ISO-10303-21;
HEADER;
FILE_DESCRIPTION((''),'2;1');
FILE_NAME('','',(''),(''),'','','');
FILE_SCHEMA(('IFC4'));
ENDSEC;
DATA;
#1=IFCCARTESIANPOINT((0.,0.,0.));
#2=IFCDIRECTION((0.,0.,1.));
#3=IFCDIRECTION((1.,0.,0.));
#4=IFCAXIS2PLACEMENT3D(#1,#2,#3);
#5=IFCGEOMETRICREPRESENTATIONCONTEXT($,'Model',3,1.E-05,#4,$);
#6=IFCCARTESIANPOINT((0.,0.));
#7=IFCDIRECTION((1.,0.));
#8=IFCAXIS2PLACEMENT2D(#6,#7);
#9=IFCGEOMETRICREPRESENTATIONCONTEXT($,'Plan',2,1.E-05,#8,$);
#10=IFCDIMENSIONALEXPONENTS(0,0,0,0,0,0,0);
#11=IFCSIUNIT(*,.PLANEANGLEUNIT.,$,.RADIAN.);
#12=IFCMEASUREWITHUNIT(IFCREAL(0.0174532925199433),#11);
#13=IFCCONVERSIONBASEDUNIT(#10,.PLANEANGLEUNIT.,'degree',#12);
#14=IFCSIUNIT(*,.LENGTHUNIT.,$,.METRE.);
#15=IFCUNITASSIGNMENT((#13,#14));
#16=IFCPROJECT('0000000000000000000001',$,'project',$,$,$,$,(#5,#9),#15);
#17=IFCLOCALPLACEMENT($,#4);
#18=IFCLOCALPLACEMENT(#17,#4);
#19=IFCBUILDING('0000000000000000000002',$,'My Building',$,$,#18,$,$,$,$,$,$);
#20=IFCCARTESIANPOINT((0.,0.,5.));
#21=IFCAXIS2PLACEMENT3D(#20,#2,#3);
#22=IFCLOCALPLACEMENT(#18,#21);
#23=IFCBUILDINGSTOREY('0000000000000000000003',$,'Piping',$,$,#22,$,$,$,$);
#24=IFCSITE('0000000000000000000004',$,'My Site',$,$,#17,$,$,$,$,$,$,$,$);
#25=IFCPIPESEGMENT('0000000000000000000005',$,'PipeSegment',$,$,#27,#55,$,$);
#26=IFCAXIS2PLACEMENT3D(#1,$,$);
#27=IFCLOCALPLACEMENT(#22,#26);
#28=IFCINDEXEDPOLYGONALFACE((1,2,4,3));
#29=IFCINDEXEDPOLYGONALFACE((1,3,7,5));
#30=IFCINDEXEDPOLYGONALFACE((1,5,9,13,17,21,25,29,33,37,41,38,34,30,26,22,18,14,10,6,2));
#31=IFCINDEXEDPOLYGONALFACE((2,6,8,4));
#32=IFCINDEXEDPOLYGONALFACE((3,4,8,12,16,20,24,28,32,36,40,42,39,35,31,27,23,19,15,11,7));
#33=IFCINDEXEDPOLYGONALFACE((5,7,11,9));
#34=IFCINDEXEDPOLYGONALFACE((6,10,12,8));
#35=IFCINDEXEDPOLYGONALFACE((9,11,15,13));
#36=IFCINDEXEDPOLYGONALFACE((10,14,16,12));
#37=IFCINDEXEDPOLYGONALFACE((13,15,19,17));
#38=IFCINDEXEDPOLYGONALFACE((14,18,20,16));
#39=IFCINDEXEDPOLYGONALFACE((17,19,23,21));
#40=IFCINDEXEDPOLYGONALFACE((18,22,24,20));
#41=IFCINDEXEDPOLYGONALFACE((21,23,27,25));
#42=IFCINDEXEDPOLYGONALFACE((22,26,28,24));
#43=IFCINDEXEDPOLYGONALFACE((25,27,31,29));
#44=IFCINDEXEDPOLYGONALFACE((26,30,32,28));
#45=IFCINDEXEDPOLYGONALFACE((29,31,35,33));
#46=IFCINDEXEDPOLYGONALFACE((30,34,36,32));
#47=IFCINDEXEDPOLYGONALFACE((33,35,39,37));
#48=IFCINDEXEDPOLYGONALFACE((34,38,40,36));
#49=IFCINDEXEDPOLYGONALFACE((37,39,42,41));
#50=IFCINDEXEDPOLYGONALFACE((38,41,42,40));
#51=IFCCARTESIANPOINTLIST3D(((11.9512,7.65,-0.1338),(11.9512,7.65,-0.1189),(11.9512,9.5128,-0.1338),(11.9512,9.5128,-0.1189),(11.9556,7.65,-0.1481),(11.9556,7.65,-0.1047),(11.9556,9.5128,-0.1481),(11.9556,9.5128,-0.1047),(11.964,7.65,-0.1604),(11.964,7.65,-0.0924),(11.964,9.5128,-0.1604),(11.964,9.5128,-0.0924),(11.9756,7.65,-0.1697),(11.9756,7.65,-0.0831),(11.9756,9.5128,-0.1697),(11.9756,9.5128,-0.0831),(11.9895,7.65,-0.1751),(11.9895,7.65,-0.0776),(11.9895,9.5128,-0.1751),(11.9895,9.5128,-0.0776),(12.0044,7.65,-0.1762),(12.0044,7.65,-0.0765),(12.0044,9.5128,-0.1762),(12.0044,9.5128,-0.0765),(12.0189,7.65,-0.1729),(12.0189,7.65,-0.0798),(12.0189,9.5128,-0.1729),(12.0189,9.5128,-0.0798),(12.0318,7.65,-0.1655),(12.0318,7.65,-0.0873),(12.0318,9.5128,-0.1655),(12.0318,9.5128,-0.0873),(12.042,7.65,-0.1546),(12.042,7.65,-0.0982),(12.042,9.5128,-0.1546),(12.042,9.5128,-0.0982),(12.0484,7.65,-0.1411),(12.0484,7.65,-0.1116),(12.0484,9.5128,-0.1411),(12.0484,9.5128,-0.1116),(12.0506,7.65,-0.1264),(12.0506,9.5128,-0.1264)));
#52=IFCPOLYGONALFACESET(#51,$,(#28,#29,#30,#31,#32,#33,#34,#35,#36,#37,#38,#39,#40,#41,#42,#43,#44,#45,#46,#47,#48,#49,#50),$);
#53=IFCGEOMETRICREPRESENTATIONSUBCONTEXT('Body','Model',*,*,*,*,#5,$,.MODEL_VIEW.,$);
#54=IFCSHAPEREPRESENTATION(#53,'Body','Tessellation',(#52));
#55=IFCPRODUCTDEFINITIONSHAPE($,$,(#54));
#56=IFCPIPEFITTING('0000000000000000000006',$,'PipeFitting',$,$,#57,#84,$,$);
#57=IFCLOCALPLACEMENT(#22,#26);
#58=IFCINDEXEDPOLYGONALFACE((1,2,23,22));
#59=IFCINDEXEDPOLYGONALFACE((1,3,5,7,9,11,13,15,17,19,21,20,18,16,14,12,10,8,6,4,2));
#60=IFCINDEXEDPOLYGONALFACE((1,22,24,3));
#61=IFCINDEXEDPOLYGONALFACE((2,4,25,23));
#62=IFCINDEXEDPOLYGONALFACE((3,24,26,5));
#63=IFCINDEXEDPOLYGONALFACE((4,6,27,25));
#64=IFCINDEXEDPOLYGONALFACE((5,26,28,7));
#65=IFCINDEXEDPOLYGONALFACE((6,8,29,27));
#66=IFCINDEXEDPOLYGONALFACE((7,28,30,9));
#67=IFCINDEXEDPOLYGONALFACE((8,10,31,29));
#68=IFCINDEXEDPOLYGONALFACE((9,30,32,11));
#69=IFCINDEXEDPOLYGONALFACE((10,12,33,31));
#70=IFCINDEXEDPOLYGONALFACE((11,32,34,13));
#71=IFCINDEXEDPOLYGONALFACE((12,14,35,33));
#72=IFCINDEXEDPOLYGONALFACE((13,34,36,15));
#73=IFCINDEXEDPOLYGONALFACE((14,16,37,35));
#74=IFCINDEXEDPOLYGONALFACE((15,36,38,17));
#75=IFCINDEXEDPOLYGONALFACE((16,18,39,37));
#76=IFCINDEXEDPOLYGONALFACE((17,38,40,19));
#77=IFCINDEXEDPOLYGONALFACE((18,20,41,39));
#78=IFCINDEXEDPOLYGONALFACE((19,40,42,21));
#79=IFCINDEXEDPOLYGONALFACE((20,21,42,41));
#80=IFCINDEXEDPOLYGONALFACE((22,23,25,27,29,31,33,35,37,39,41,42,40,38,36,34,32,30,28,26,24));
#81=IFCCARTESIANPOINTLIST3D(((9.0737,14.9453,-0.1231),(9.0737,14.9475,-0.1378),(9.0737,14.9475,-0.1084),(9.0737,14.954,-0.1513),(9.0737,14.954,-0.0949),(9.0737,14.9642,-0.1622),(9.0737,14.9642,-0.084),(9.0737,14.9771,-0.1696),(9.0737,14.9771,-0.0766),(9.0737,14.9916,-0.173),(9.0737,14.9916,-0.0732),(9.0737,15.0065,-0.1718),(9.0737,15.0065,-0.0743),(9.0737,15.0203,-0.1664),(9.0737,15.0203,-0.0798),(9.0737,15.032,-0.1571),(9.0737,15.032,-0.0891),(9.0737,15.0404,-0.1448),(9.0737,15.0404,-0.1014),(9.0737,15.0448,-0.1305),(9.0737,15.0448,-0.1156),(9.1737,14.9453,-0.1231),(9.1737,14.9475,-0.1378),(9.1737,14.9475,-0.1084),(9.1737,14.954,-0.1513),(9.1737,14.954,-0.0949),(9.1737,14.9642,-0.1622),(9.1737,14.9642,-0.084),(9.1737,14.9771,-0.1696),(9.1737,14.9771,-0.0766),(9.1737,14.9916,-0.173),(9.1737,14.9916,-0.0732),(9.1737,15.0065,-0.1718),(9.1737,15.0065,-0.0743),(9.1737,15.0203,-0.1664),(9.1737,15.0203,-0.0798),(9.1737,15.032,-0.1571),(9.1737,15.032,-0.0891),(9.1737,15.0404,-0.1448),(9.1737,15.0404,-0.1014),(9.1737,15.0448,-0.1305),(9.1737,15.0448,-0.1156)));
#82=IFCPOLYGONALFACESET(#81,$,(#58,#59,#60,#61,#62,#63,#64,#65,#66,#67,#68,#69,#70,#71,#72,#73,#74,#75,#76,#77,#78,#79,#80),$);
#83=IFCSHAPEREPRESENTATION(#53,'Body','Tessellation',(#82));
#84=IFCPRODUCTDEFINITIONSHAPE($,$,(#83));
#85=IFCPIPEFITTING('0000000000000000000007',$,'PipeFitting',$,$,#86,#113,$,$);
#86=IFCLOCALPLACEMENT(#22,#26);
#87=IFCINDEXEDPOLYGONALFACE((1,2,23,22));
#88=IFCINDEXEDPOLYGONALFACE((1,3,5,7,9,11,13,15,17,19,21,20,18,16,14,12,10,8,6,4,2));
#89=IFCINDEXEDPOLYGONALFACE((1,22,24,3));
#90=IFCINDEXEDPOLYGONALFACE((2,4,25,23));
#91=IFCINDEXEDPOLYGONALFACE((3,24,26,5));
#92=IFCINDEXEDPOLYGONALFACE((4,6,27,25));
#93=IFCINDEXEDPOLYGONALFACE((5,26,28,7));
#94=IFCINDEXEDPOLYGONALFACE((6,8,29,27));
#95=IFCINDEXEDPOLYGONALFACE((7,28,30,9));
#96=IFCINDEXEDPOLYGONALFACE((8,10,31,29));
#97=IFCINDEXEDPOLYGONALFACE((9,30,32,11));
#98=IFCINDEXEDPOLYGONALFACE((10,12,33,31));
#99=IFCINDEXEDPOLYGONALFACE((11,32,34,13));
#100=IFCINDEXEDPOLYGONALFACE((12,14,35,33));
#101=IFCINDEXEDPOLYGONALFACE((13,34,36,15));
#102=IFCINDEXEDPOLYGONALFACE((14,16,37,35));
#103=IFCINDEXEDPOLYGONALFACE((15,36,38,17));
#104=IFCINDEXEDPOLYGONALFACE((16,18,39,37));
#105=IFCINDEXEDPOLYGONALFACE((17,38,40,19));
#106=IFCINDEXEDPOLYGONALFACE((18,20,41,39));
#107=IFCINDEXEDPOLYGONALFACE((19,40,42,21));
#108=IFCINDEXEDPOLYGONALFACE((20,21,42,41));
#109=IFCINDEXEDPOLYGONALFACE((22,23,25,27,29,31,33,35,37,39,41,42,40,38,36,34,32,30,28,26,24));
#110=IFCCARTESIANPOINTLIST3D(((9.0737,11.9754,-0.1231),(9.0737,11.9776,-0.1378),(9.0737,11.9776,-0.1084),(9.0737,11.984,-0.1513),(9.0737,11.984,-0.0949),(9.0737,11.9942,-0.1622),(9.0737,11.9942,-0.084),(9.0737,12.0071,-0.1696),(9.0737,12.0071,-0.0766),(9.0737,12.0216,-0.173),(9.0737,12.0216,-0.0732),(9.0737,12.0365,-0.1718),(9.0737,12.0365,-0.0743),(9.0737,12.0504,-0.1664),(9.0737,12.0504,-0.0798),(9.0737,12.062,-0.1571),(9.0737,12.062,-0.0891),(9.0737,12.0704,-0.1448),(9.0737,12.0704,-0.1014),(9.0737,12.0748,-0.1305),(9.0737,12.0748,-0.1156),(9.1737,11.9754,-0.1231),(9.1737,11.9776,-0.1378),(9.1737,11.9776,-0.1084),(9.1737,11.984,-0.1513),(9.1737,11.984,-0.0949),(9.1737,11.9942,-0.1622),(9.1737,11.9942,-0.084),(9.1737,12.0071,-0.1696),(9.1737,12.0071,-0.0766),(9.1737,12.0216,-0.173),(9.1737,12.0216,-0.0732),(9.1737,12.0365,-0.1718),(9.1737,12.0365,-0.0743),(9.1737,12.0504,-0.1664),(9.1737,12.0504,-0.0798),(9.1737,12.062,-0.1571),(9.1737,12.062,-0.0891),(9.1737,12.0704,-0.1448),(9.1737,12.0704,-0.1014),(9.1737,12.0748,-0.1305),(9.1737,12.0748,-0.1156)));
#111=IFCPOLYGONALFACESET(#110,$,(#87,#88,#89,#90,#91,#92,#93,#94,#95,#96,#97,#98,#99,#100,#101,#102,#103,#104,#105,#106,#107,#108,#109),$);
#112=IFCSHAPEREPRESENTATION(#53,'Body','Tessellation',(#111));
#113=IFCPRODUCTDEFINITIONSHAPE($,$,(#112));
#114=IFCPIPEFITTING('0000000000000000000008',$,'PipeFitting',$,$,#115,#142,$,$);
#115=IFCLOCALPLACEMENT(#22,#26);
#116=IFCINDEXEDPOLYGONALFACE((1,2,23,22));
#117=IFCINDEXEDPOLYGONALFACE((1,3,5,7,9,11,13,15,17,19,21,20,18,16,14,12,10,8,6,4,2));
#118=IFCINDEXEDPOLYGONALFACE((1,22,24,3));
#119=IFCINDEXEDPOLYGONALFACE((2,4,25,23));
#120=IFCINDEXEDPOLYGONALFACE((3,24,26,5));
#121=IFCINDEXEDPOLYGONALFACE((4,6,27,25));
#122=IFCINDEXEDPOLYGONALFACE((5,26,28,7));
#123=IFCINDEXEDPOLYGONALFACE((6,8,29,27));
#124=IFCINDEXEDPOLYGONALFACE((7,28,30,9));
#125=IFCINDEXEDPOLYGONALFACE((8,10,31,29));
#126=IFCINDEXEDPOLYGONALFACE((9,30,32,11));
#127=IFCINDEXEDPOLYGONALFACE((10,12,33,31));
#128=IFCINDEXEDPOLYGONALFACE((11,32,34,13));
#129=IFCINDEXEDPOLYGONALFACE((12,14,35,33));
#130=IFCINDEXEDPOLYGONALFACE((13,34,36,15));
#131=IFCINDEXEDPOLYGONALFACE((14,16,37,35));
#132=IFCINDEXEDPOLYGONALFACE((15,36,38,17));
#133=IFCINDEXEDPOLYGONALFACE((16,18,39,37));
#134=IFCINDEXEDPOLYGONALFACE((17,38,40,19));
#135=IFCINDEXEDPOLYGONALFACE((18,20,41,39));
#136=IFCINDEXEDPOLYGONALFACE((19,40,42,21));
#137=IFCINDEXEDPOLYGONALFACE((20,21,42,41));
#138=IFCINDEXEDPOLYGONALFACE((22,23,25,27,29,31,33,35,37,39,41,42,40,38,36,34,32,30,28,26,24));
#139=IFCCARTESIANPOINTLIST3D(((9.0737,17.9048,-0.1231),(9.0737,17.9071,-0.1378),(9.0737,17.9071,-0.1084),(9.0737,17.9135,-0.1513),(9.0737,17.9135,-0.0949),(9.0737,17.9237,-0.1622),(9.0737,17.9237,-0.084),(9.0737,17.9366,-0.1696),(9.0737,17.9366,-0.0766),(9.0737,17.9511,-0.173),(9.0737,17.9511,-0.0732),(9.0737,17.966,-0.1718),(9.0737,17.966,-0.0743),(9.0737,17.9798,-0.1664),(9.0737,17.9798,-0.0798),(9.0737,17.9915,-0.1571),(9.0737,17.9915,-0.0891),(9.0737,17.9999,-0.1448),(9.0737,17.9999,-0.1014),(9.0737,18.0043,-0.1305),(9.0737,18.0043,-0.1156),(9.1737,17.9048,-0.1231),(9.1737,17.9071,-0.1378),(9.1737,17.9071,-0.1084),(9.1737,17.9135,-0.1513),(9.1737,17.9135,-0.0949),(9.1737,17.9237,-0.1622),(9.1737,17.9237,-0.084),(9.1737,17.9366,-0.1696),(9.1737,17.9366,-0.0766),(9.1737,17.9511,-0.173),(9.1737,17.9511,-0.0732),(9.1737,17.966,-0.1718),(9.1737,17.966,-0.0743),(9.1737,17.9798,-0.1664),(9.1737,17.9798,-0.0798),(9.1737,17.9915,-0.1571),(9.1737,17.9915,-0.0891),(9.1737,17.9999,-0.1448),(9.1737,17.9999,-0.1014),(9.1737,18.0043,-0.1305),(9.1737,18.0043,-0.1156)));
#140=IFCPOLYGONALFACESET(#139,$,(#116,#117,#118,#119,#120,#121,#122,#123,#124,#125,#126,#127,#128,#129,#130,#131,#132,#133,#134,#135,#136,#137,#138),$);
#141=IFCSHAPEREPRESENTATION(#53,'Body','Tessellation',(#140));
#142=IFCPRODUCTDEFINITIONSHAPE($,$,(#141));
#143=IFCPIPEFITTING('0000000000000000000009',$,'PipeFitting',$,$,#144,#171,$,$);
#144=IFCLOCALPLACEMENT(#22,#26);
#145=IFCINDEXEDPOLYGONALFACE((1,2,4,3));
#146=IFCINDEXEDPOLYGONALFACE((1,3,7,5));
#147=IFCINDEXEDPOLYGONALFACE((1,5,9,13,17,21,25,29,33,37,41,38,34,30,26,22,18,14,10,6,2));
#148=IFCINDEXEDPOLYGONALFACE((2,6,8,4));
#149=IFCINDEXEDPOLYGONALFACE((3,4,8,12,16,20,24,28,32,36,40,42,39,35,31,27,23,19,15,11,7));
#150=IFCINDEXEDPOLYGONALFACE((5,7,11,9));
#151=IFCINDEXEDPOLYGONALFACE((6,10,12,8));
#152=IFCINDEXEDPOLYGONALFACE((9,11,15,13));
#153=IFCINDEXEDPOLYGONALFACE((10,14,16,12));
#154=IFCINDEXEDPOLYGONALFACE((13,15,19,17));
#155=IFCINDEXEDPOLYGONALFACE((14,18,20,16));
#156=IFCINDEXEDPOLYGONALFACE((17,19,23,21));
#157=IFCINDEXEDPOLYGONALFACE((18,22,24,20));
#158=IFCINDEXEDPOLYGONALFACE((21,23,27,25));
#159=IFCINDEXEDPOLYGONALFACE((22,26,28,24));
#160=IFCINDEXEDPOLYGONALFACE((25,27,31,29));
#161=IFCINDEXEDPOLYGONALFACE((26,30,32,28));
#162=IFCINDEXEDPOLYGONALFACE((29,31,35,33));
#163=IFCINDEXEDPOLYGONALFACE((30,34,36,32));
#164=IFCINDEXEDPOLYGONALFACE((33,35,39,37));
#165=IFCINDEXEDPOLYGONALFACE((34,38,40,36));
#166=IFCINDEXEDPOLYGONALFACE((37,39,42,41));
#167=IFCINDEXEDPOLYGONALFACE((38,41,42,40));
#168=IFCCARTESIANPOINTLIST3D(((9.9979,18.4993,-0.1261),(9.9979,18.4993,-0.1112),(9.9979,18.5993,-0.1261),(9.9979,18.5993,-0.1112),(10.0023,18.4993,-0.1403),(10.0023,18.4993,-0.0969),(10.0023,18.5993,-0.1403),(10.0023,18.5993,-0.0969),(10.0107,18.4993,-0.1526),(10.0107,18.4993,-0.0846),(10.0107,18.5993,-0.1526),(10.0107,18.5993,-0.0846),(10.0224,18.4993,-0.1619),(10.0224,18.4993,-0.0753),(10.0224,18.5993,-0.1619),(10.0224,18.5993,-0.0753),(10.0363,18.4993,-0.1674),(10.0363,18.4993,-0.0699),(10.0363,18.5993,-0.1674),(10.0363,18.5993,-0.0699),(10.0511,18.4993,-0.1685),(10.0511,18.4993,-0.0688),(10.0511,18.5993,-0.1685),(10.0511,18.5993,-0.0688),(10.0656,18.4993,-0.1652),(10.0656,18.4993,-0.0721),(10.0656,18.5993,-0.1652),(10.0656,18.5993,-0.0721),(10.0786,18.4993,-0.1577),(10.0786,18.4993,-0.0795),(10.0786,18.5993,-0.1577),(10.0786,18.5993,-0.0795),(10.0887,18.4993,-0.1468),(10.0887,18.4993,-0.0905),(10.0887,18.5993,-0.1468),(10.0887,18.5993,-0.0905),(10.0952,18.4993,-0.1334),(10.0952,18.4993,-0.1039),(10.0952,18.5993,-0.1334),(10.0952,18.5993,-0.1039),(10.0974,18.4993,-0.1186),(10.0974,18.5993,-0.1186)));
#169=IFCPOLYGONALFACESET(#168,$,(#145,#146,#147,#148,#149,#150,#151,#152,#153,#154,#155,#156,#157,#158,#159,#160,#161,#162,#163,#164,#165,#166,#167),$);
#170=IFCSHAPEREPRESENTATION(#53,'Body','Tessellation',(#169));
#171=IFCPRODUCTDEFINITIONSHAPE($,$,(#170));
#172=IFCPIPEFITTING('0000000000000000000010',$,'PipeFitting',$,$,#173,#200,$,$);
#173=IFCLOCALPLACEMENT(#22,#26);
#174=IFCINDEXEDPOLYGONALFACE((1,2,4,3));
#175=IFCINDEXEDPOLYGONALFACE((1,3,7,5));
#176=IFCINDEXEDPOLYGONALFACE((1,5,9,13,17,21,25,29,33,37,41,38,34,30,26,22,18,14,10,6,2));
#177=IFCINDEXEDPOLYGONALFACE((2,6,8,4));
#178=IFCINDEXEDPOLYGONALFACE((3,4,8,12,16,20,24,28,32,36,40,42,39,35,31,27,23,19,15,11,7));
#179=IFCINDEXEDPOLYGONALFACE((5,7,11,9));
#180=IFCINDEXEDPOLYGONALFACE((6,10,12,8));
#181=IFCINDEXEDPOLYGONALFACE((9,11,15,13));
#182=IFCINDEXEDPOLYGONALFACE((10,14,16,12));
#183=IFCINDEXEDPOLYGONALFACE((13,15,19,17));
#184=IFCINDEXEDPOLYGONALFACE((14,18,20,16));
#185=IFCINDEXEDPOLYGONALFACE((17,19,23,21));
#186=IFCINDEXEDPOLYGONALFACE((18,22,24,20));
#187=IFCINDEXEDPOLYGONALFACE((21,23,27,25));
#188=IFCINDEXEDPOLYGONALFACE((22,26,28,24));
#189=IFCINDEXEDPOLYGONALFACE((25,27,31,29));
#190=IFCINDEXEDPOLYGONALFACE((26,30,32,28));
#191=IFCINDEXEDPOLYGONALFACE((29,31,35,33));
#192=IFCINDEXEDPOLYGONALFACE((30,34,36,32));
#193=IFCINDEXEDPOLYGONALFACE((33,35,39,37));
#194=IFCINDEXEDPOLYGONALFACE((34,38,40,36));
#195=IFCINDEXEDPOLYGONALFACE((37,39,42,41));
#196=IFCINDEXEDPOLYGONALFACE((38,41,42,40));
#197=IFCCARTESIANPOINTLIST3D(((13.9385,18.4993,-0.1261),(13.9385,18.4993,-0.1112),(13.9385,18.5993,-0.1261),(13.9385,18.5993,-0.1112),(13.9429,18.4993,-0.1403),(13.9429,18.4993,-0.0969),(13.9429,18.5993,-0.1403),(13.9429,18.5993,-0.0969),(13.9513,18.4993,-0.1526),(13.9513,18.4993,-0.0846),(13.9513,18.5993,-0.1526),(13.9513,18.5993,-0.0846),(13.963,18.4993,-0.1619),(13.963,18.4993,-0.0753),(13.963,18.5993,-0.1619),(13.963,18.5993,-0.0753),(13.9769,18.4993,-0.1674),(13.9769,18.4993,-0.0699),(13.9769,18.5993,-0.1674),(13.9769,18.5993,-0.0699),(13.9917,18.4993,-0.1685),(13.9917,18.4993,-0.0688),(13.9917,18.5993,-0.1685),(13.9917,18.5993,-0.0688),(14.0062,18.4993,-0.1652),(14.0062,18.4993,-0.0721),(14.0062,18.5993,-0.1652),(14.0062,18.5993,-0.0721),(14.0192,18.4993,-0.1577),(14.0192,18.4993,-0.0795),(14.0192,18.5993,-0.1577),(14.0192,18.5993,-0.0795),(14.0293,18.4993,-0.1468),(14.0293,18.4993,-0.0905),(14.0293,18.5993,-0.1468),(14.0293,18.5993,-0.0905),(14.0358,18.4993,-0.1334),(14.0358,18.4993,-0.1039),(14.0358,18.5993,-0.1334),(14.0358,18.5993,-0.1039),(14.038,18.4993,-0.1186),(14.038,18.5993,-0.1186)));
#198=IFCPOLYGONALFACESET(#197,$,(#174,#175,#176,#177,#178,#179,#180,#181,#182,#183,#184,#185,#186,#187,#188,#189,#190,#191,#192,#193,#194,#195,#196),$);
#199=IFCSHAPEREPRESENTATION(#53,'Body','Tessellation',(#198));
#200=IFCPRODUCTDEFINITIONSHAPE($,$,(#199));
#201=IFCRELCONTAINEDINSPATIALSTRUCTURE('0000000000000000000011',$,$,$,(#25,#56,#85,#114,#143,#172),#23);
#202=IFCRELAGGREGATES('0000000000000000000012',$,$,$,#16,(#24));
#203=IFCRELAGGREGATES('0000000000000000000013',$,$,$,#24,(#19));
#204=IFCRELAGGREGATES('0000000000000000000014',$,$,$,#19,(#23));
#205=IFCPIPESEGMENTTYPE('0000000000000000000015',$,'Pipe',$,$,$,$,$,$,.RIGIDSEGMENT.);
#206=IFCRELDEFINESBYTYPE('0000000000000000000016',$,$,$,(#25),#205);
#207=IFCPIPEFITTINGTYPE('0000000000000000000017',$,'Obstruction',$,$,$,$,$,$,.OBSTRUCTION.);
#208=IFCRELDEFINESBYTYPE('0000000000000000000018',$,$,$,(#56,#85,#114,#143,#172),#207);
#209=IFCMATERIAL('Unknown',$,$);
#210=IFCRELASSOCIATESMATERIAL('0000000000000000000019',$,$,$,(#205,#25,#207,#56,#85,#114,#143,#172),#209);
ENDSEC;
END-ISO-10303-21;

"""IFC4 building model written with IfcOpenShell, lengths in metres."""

from ifc_helpers import new_model, entity, si_unit, converted_unit, frame, origin_with_axes, origin_2d_with_axis, place, context, subcontext, project, spatial, circle, extrude, material, material_profile, profile_set, profile_usage, type_object, element, save


model = new_model("IFC4")

# Units and contexts
model_context = context("Model", 3, precision=1e-05, world=origin_with_axes())
plan_context = context("Plan", 2, precision=1e-05, world=origin_2d_with_axis())
body_context = subcontext(model_context, "Body", "Model", "MODEL_VIEW")
ifc_project = project(units=[converted_unit("PLANEANGLEUNIT", "degree", entity("IfcReal", 0.0174532925199433), si_unit("PLANEANGLEUNIT", "RADIAN"), dimensions=[0, 0, 0, 0, 0, 0, 0]), si_unit("LENGTHUNIT", "METRE")], contexts=[model_context, plan_context])

# Site, building, storey
site_placement = place(None, origin_with_axes())
site = spatial("IfcSite", under=ifc_project, at=site_placement, Name="My Site")
building_placement = place(site_placement, origin_with_axes())
building = spatial("IfcBuilding", under=site, at=building_placement, Name="My Building")
storey_placement = place(building_placement, frame((0.0, 0.0, 5.0), z_axis=(0.0, 0.0, 1.0), x_axis=(1.0, 0.0, 0.0)))
storey = spatial("IfcBuildingStorey", under=building, at=storey_placement, Name="Piping")

# Pipe segment
ifc_material = material(Name="Unknown")
ifc_material_profile_1 = material_profile(ifc_material, circle(Radius=0.05))
ifc_profile_set_1 = profile_set([ifc_material_profile_1])
pipe_segment_type = type_object("IfcPipeSegmentType", Name="Pipe", PredefinedType="RIGIDSEGMENT", material=ifc_profile_set_1)
ifc_profile_usage_1 = profile_usage(ifc_profile_set_1, cardinal=5)
pipe_segment_1_placement = place(storey_placement, frame((12.0006, 9.5128, -0.1264), z_axis=(0.0, -1.0, 0.0), x_axis=(1.0, 0.0, 0.0)))
element("IfcPipeSegment", 1, at=pipe_segment_1_placement, inside=storey, type_object=pipe_segment_type, material=ifc_profile_usage_1, Name="PipeSegment", context=body_context, shape_type="SweptSolid", body=[
    extrude(circle(Radius=0.05), origin_with_axes(), (0.0, 0.0, 1.0), 1.8629),
])

# Pipe fittings
ifc_material_profile_2 = material_profile(ifc_material, circle(Radius=0.05))
ifc_profile_set_2 = profile_set([ifc_material_profile_2])
ifc_profile_usage_2 = profile_usage(ifc_profile_set_2, cardinal=5)
pipe_fitting_type_1 = type_object("IfcPipeFittingType", Name="Obstruction", PredefinedType="OBSTRUCTION", material=ifc_profile_set_2)
pipe_fitting_1_placement = place(storey_placement, frame((9.1737, 14.9953, -0.1231), z_axis=(-1.0, 0.0, 0.0), x_axis=(0.0, -1.0, 0.0)))
element("IfcPipeFitting", 2, at=pipe_fitting_1_placement, inside=storey, type_object=pipe_fitting_type_1, material=ifc_profile_usage_2, Name="PipeFitting", context=body_context, shape_type="SweptSolid", body=[
    extrude(circle(Radius=0.05), origin_with_axes(), (0.0, 0.0, 1.0), 0.1),
])
ifc_profile_usage_3 = profile_usage(ifc_profile_set_2, cardinal=5)
pipe_fitting_2_placement = place(storey_placement, frame((9.1737, 12.0254, -0.1231), z_axis=(-1.0, 0.0, 0.0), x_axis=(0.0, -1.0, 0.0)))
element("IfcPipeFitting", 3, at=pipe_fitting_2_placement, inside=storey, type_object=pipe_fitting_type_1, material=ifc_profile_usage_3, Name="PipeFitting", context=body_context, shape_type="SweptSolid", body=[
    extrude(circle(Radius=0.05), origin_with_axes(), (0.0, 0.0, 1.0), 0.1),
])
ifc_profile_usage_4 = profile_usage(ifc_profile_set_2, cardinal=5)
pipe_fitting_3_placement = place(storey_placement, frame((9.1737, 17.9548, -0.1231), z_axis=(-1.0, 0.0, 0.0), x_axis=(0.0, -1.0, 0.0)))
element("IfcPipeFitting", 4, at=pipe_fitting_3_placement, inside=storey, type_object=pipe_fitting_type_1, material=ifc_profile_usage_4, Name="PipeFitting", context=body_context, shape_type="SweptSolid", body=[
    extrude(circle(Radius=0.05), origin_with_axes(), (0.0, 0.0, 1.0), 0.1),
])
ifc_profile_usage_5 = profile_usage(ifc_profile_set_2, cardinal=5)
pipe_fitting_4_placement = place(storey_placement, frame((10.0474, 18.5993, -0.1186), z_axis=(0.0, -1.0, 0.0), x_axis=(1.0, 0.0, 0.0)))
element("IfcPipeFitting", 5, at=pipe_fitting_4_placement, inside=storey, type_object=pipe_fitting_type_1, material=ifc_profile_usage_5, Name="PipeFitting", context=body_context, shape_type="SweptSolid", body=[
    extrude(circle(Radius=0.05), origin_with_axes(), (0.0, 0.0, 1.0), 0.1),
])
ifc_profile_usage_6 = profile_usage(ifc_profile_set_2, cardinal=5)
pipe_fitting_5_placement = place(storey_placement, frame((13.988, 18.5993, -0.1186), z_axis=(0.0, -1.0, 0.0), x_axis=(1.0, 0.0, 0.0)))
element("IfcPipeFitting", 6, at=pipe_fitting_5_placement, inside=storey, type_object=pipe_fitting_type_1, material=ifc_profile_usage_6, Name="PipeFitting", context=body_context, shape_type="SweptSolid", body=[
    extrude(circle(Radius=0.05), origin_with_axes(), (0.0, 0.0, 1.0), 0.1),
])

save(model, "model.ifc")
